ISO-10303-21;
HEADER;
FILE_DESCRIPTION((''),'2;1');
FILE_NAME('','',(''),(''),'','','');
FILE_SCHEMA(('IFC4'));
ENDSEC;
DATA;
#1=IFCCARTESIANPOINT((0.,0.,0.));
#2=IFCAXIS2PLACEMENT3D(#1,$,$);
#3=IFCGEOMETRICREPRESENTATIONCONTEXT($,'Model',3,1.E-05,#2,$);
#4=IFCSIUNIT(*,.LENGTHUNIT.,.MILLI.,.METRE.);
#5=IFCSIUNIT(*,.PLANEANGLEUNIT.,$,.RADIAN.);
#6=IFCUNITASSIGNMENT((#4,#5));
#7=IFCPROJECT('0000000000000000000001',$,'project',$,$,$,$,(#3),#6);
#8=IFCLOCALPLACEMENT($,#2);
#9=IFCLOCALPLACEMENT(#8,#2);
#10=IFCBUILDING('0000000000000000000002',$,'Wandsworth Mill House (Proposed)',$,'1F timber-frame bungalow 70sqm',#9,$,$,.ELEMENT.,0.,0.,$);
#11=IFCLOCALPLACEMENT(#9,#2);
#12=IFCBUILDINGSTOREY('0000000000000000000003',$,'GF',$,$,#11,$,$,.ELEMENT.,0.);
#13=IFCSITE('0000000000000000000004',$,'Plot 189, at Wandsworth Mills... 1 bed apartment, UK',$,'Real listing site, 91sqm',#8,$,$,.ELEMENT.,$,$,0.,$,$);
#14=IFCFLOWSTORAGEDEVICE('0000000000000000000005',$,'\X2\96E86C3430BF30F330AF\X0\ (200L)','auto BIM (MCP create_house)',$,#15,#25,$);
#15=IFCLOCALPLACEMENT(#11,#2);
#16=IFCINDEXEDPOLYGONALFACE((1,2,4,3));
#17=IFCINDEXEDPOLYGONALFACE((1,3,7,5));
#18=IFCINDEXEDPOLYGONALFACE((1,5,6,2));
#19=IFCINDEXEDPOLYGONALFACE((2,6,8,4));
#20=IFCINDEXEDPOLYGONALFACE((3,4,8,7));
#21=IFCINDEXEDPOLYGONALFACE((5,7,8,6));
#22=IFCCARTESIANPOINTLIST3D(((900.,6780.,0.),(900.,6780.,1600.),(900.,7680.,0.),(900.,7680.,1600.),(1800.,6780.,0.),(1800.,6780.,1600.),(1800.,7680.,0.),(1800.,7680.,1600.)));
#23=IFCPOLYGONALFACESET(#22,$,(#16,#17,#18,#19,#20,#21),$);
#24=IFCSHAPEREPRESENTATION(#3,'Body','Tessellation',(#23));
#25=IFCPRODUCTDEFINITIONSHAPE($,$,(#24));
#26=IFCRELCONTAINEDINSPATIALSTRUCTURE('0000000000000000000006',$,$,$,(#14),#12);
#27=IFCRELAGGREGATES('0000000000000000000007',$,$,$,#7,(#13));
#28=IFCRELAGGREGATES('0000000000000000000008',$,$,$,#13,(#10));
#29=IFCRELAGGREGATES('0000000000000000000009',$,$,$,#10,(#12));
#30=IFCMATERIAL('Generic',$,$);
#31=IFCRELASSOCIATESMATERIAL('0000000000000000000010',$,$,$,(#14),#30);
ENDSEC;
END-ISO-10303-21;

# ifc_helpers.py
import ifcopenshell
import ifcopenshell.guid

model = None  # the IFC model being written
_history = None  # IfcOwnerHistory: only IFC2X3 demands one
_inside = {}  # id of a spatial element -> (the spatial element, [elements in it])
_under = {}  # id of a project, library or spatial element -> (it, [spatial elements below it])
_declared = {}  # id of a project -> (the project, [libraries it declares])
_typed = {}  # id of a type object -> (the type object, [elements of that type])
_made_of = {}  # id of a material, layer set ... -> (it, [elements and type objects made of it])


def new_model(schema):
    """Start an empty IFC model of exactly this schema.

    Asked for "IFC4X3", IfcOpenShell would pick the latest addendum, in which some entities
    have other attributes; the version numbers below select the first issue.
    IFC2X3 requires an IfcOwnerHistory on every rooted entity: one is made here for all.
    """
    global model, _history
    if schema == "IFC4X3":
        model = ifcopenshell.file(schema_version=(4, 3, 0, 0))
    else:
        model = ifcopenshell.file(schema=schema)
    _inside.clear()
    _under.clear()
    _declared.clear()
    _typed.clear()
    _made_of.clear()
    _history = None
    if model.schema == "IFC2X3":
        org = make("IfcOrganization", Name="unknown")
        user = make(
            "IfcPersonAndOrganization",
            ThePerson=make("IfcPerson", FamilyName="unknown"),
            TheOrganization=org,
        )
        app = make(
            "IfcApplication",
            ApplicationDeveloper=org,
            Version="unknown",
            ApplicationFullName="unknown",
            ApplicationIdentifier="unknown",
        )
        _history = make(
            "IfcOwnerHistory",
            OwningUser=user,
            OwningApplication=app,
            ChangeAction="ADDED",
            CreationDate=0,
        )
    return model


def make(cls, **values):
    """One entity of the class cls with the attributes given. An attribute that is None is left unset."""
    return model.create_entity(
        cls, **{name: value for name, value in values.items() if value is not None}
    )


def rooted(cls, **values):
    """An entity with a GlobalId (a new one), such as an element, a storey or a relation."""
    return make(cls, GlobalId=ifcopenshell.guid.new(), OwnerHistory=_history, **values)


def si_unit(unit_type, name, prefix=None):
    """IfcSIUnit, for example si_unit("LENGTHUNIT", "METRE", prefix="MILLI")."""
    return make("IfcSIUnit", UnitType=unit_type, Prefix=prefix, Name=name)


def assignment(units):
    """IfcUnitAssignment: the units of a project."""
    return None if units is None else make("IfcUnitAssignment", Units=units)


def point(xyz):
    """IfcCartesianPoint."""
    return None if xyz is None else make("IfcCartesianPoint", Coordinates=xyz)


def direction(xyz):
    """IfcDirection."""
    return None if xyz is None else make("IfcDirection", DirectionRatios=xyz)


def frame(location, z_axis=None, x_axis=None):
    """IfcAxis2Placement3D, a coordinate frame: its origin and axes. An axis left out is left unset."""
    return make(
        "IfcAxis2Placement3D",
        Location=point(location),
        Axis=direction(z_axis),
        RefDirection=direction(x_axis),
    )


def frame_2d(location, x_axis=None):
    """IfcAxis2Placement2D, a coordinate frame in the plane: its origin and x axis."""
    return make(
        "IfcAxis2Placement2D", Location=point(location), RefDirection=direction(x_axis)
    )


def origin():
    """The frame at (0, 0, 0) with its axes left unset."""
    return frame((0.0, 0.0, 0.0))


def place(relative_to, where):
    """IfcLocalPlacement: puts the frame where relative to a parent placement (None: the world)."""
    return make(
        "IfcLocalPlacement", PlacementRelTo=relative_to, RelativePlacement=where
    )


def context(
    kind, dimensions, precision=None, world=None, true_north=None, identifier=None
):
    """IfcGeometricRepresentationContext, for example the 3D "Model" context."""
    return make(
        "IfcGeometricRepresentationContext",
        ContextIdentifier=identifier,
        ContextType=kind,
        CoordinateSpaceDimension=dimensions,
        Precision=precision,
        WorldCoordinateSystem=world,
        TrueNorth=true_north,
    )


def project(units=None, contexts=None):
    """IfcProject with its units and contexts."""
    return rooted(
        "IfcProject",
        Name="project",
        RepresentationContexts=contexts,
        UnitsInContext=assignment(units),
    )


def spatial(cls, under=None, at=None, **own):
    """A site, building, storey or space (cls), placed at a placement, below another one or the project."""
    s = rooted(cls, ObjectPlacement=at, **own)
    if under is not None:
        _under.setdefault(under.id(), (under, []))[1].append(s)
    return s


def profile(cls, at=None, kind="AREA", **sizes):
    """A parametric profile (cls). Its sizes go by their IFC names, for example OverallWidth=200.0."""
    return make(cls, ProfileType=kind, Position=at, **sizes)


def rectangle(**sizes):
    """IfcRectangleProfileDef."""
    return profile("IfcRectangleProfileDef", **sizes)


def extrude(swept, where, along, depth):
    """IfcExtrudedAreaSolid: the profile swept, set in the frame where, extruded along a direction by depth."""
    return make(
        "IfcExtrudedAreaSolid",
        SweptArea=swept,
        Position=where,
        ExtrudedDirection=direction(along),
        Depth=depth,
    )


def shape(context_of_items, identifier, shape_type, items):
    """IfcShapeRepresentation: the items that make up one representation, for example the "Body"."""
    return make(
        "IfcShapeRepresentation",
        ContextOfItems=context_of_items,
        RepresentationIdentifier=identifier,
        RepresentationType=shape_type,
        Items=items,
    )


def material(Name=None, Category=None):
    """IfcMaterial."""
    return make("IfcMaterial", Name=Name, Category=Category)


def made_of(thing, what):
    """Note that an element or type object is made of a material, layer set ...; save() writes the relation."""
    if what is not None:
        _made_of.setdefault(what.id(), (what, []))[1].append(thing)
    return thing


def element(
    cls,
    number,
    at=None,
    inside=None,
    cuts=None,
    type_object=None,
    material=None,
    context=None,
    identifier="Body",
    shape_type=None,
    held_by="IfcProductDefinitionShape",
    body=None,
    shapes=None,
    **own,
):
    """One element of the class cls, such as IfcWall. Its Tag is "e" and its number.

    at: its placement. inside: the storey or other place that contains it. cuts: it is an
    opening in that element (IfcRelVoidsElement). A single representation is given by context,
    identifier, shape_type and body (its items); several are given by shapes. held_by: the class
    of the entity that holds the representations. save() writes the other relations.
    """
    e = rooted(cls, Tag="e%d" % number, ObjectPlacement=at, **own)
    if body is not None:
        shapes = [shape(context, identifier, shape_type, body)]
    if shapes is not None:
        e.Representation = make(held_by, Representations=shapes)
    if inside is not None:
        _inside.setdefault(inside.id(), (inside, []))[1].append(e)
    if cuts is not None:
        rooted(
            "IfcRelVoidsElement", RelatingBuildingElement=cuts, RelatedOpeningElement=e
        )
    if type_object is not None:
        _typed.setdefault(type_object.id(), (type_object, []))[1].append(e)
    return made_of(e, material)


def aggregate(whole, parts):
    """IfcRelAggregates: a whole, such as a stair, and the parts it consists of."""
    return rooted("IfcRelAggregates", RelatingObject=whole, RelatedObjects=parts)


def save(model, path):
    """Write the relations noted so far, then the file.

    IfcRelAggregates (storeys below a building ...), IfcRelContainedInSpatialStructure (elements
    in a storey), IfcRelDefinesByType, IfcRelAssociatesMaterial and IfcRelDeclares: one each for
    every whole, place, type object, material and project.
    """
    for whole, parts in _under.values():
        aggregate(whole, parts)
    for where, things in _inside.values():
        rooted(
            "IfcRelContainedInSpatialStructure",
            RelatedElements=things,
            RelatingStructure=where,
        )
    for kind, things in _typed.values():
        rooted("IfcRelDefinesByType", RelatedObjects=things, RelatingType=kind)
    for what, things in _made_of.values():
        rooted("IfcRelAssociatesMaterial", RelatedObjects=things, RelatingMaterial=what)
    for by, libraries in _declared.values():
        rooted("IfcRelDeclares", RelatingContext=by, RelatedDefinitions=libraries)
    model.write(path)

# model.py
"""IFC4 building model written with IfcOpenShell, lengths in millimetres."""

from ifc_helpers import new_model, si_unit, frame, frame_2d, origin, place, context, project, spatial, rectangle, extrude, material, element, save


model = new_model("IFC4")

# Units and contexts
model_context = context("Model", 3, precision=1e-05, world=origin())
ifc_project = project(units=[si_unit("LENGTHUNIT", "METRE", prefix="MILLI"), si_unit("PLANEANGLEUNIT", "RADIAN")], contexts=[model_context])

# Site, building, storey
site_placement = place(None, origin())
site = spatial("IfcSite", under=ifc_project, at=site_placement, Name="Plot 189, at Wandsworth Mills... 1 bed apartment, UK", ObjectType="Real listing site, 91sqm", CompositionType="ELEMENT", RefElevation=0.0)
building_placement = place(site_placement, origin())
building = spatial("IfcBuilding", under=site, at=building_placement, Name="Wandsworth Mill House (Proposed)", ObjectType="1F timber-frame bungalow 70sqm", CompositionType="ELEMENT", ElevationOfRefHeight=0.0, ElevationOfTerrain=0.0)
storey_placement = place(building_placement, origin())
storey = spatial("IfcBuildingStorey", under=building, at=storey_placement, Name="GF", CompositionType="ELEMENT", Elevation=0.0)

# Flow storage device
ifc_material_1 = material(Name="Generic")
flow_storage_device_placement = place(storey_placement, frame((450.0, 3390.0, 0.0)))
element("IfcFlowStorageDevice", 1, at=flow_storage_device_placement, inside=storey, material=ifc_material_1, Name="雨水タンク (200L)", Description="auto BIM (MCP create_house)", context=model_context, shape_type="SweptSolid", body=[
    extrude(rectangle(XDim=900.0, YDim=900.0, at=frame_2d((450.0, 450.0))), frame((450.0, 3390.0, 0.0)), (0.0, 0.0, 1.0), 1600.0),
])

save(model, "model.ifc")
